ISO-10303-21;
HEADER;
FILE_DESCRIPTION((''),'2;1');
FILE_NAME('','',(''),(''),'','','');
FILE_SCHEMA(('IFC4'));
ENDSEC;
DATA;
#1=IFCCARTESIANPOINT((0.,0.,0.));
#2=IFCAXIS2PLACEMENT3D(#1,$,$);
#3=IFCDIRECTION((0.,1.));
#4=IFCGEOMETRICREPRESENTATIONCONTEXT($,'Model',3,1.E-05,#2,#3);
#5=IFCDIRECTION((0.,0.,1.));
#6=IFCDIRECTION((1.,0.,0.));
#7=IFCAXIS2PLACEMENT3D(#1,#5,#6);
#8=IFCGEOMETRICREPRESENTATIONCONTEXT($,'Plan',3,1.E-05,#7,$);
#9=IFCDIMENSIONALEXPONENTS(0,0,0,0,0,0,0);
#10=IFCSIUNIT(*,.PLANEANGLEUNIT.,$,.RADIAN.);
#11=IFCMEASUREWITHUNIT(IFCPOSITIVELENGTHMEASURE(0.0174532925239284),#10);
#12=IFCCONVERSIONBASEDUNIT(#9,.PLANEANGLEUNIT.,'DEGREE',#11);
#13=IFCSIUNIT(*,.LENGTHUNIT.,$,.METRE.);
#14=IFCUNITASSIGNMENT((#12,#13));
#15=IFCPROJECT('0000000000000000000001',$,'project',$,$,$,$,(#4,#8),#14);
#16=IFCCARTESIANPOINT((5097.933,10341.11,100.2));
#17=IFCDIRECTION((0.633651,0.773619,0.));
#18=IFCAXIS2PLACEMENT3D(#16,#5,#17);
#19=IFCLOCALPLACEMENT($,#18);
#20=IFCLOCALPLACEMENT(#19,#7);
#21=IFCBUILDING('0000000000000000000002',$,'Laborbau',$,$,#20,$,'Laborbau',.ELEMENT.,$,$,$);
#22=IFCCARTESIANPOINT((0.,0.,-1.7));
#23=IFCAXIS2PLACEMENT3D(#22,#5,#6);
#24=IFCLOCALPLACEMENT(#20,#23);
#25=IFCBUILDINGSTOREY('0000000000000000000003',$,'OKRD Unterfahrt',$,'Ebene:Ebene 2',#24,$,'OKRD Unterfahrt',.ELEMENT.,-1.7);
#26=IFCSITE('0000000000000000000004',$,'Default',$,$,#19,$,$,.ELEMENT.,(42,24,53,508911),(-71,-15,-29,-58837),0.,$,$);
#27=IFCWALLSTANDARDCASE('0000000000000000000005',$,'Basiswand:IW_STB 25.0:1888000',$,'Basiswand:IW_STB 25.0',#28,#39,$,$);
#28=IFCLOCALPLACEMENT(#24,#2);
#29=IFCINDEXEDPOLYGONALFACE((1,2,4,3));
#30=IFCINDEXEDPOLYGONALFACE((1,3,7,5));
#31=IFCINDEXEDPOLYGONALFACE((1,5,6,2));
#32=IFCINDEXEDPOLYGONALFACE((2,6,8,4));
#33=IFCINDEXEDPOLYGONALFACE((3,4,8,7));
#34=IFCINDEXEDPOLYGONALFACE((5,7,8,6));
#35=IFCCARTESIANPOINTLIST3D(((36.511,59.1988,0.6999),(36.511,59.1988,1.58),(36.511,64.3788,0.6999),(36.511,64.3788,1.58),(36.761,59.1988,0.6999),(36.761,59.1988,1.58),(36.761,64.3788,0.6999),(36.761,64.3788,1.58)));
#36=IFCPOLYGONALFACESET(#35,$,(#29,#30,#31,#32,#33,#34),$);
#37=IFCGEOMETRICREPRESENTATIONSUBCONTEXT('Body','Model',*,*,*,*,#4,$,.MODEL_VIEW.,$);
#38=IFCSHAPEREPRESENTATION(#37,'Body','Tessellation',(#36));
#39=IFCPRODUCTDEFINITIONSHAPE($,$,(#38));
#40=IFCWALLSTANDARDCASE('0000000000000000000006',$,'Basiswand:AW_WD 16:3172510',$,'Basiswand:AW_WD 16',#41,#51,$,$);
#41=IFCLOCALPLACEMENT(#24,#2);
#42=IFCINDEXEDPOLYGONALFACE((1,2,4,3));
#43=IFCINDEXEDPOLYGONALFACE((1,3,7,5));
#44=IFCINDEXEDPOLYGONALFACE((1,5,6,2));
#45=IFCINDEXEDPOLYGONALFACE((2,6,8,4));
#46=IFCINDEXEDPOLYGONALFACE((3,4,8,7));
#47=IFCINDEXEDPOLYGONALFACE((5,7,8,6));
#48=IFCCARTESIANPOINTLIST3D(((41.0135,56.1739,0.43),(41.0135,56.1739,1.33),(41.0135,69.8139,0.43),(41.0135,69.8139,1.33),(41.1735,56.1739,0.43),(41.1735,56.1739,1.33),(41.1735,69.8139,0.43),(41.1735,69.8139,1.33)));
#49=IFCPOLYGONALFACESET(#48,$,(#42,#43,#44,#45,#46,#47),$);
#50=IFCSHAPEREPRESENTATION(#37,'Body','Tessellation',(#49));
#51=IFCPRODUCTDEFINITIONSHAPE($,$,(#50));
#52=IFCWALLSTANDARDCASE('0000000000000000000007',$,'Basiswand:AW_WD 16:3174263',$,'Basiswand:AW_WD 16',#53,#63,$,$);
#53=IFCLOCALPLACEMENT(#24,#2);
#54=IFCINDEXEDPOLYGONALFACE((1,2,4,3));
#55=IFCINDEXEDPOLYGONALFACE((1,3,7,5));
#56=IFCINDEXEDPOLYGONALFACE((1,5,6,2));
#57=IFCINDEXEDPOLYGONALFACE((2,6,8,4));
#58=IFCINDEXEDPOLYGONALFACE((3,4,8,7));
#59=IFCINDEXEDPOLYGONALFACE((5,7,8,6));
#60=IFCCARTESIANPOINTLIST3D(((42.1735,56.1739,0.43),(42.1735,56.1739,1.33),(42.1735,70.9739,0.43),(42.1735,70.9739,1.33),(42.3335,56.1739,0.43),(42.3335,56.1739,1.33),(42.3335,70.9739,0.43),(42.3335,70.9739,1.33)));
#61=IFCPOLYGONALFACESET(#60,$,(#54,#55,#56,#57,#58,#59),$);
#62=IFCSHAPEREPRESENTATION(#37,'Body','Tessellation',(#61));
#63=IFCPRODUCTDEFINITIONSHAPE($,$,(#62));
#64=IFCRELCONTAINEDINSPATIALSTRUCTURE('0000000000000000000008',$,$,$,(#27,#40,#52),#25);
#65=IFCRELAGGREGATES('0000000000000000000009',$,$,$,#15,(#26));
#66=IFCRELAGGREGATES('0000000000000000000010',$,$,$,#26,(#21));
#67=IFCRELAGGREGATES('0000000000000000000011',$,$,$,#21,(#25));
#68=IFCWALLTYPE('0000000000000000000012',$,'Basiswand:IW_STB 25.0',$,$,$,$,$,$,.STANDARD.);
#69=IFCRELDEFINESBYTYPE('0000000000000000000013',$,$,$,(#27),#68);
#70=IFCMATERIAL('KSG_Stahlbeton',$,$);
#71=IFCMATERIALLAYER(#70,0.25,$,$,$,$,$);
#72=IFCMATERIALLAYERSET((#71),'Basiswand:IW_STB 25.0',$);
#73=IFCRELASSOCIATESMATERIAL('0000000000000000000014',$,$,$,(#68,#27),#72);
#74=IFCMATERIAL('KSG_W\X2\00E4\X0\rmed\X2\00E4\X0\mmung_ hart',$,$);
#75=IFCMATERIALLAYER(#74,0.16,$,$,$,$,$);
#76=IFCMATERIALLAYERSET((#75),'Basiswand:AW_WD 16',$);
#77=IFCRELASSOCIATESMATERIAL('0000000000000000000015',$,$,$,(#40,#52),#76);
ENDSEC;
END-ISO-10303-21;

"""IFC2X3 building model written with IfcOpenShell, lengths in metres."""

from ifc_helpers import new_model, entity, si_unit, converted_unit, direction, frame, frame_2d, origin, origin_with_axes, place, context, subcontext, project, spatial, rectangle, extrude, material, layer, layer_set, layer_usage, type_object, element, save


model = new_model("IFC2X3")

# Units and contexts
model_context = context("Model", 3, precision=1e-05, world=origin(), true_north=direction((0.0, 1.0)))
plan_context = context("Plan", 3, precision=1e-05, world=origin_with_axes())
body_context = subcontext(model_context, "Body", "Model", "MODEL_VIEW")
ifc_project = project(units=[converted_unit("PLANEANGLEUNIT", "DEGREE", entity("IfcPositiveLengthMeasure", 0.0174532925239284), si_unit("PLANEANGLEUNIT", "RADIAN"), dimensions=[0, 0, 0, 0, 0, 0, 0]), si_unit("LENGTHUNIT", "METRE")], contexts=[model_context, plan_context])

# Site, building, storey
site_placement = place(None, frame((5097.933, 10341.11, 100.2), z_axis=(0.0, 0.0, 1.0), x_axis=(0.633651, 0.773619, 0.0)))
site = spatial("IfcSite", under=ifc_project, at=site_placement, Name="Default", CompositionType="ELEMENT", RefLatitude=(42, 24, 53, 508911), RefLongitude=(-71, -15, -29, -58837), RefElevation=0.0)
building_placement = place(site_placement, origin_with_axes())
building = spatial("IfcBuilding", under=site, at=building_placement, Name="Laborbau", LongName="Laborbau", CompositionType="ELEMENT")
storey_placement = place(building_placement, frame((0.0, 0.0, -1.7), z_axis=(0.0, 0.0, 1.0), x_axis=(1.0, 0.0, 0.0)))
storey = spatial("IfcBuildingStorey", under=building, at=storey_placement, Name="OKRD Unterfahrt", ObjectType="Ebene:Ebene 2", LongName="OKRD Unterfahrt", CompositionType="ELEMENT", Elevation=-1.7)

# Wall
ifc_material_1 = material(Name="KSG_Stahlbeton")
ifc_layer_1 = layer(ifc_material_1, 0.25)
ifc_layer_set_1 = layer_set([ifc_layer_1], Name="Basiswand:IW_STB 25.0")
ifc_layer_usage_1 = layer_usage(ifc_layer_set_1, "AXIS2", "NEGATIVE", 0.125)
wall_type = type_object("IfcWallType", Name="Basiswand:IW_STB 25.0", PredefinedType="STANDARD", material=ifc_layer_set_1)
wall_1_placement = place(storey_placement, frame((36.636, 59.1988, 0.6999), z_axis=(0.0, 0.0, 1.0), x_axis=(0.0, 1.0, 0.0)))
element("IfcWallStandardCase", 1, at=wall_1_placement, inside=storey, type_object=wall_type, material=ifc_layer_usage_1, Name="Basiswand:IW_STB 25.0:1888000", ObjectType="Basiswand:IW_STB 25.0", context=body_context, shape_type="SweptSolid", body=[
    extrude(rectangle(XDim=5.18, YDim=0.25, at=frame_2d((2.59, 0.0), x_axis=(-1.0, 0.0))), origin(), (0.0, 0.0, 1.0), 0.8801),
])

# Walls
ifc_material_2 = material(Name="KSG_Wärmedämmung_ hart")
ifc_layer_2 = layer(ifc_material_2, 0.16)
ifc_layer_set_2 = layer_set([ifc_layer_2], Name="Basiswand:AW_WD 16")
ifc_layer_usage_2 = layer_usage(ifc_layer_set_2, "AXIS2", "NEGATIVE", 0.08)
wall_2_placement = place(storey_placement, frame((41.0935, 56.1739, 0.43), z_axis=(0.0, 0.0, 1.0), x_axis=(0.0, 1.0, 0.0)))
element("IfcWallStandardCase", 2, at=wall_2_placement, inside=storey, material=ifc_layer_usage_2, Name="Basiswand:AW_WD 16:3172510", ObjectType="Basiswand:AW_WD 16", context=body_context, shape_type="SweptSolid", body=[
    extrude(rectangle(XDim=13.64, YDim=0.16, at=frame_2d((6.82, 0.0), x_axis=(-1.0, 0.0))), origin(), (0.0, 0.0, 1.0), 0.9),
])
ifc_layer_usage_3 = layer_usage(ifc_layer_set_2, "AXIS2", "NEGATIVE", 0.08)
wall_3_placement = place(storey_placement, frame((42.2535, 56.1739, 0.43), z_axis=(0.0, 0.0, 1.0), x_axis=(0.0, 1.0, 0.0)))
element("IfcWallStandardCase", 3, at=wall_3_placement, inside=storey, material=ifc_layer_usage_3, Name="Basiswand:AW_WD 16:3174263", ObjectType="Basiswand:AW_WD 16", context=body_context, shape_type="SweptSolid", body=[
    extrude(rectangle(XDim=14.8, YDim=0.16, at=frame_2d((7.4, 0.0), x_axis=(-1.0, 0.0))), origin(), (0.0, 0.0, 1.0), 0.9),
])

save(model, "model.ifc")
